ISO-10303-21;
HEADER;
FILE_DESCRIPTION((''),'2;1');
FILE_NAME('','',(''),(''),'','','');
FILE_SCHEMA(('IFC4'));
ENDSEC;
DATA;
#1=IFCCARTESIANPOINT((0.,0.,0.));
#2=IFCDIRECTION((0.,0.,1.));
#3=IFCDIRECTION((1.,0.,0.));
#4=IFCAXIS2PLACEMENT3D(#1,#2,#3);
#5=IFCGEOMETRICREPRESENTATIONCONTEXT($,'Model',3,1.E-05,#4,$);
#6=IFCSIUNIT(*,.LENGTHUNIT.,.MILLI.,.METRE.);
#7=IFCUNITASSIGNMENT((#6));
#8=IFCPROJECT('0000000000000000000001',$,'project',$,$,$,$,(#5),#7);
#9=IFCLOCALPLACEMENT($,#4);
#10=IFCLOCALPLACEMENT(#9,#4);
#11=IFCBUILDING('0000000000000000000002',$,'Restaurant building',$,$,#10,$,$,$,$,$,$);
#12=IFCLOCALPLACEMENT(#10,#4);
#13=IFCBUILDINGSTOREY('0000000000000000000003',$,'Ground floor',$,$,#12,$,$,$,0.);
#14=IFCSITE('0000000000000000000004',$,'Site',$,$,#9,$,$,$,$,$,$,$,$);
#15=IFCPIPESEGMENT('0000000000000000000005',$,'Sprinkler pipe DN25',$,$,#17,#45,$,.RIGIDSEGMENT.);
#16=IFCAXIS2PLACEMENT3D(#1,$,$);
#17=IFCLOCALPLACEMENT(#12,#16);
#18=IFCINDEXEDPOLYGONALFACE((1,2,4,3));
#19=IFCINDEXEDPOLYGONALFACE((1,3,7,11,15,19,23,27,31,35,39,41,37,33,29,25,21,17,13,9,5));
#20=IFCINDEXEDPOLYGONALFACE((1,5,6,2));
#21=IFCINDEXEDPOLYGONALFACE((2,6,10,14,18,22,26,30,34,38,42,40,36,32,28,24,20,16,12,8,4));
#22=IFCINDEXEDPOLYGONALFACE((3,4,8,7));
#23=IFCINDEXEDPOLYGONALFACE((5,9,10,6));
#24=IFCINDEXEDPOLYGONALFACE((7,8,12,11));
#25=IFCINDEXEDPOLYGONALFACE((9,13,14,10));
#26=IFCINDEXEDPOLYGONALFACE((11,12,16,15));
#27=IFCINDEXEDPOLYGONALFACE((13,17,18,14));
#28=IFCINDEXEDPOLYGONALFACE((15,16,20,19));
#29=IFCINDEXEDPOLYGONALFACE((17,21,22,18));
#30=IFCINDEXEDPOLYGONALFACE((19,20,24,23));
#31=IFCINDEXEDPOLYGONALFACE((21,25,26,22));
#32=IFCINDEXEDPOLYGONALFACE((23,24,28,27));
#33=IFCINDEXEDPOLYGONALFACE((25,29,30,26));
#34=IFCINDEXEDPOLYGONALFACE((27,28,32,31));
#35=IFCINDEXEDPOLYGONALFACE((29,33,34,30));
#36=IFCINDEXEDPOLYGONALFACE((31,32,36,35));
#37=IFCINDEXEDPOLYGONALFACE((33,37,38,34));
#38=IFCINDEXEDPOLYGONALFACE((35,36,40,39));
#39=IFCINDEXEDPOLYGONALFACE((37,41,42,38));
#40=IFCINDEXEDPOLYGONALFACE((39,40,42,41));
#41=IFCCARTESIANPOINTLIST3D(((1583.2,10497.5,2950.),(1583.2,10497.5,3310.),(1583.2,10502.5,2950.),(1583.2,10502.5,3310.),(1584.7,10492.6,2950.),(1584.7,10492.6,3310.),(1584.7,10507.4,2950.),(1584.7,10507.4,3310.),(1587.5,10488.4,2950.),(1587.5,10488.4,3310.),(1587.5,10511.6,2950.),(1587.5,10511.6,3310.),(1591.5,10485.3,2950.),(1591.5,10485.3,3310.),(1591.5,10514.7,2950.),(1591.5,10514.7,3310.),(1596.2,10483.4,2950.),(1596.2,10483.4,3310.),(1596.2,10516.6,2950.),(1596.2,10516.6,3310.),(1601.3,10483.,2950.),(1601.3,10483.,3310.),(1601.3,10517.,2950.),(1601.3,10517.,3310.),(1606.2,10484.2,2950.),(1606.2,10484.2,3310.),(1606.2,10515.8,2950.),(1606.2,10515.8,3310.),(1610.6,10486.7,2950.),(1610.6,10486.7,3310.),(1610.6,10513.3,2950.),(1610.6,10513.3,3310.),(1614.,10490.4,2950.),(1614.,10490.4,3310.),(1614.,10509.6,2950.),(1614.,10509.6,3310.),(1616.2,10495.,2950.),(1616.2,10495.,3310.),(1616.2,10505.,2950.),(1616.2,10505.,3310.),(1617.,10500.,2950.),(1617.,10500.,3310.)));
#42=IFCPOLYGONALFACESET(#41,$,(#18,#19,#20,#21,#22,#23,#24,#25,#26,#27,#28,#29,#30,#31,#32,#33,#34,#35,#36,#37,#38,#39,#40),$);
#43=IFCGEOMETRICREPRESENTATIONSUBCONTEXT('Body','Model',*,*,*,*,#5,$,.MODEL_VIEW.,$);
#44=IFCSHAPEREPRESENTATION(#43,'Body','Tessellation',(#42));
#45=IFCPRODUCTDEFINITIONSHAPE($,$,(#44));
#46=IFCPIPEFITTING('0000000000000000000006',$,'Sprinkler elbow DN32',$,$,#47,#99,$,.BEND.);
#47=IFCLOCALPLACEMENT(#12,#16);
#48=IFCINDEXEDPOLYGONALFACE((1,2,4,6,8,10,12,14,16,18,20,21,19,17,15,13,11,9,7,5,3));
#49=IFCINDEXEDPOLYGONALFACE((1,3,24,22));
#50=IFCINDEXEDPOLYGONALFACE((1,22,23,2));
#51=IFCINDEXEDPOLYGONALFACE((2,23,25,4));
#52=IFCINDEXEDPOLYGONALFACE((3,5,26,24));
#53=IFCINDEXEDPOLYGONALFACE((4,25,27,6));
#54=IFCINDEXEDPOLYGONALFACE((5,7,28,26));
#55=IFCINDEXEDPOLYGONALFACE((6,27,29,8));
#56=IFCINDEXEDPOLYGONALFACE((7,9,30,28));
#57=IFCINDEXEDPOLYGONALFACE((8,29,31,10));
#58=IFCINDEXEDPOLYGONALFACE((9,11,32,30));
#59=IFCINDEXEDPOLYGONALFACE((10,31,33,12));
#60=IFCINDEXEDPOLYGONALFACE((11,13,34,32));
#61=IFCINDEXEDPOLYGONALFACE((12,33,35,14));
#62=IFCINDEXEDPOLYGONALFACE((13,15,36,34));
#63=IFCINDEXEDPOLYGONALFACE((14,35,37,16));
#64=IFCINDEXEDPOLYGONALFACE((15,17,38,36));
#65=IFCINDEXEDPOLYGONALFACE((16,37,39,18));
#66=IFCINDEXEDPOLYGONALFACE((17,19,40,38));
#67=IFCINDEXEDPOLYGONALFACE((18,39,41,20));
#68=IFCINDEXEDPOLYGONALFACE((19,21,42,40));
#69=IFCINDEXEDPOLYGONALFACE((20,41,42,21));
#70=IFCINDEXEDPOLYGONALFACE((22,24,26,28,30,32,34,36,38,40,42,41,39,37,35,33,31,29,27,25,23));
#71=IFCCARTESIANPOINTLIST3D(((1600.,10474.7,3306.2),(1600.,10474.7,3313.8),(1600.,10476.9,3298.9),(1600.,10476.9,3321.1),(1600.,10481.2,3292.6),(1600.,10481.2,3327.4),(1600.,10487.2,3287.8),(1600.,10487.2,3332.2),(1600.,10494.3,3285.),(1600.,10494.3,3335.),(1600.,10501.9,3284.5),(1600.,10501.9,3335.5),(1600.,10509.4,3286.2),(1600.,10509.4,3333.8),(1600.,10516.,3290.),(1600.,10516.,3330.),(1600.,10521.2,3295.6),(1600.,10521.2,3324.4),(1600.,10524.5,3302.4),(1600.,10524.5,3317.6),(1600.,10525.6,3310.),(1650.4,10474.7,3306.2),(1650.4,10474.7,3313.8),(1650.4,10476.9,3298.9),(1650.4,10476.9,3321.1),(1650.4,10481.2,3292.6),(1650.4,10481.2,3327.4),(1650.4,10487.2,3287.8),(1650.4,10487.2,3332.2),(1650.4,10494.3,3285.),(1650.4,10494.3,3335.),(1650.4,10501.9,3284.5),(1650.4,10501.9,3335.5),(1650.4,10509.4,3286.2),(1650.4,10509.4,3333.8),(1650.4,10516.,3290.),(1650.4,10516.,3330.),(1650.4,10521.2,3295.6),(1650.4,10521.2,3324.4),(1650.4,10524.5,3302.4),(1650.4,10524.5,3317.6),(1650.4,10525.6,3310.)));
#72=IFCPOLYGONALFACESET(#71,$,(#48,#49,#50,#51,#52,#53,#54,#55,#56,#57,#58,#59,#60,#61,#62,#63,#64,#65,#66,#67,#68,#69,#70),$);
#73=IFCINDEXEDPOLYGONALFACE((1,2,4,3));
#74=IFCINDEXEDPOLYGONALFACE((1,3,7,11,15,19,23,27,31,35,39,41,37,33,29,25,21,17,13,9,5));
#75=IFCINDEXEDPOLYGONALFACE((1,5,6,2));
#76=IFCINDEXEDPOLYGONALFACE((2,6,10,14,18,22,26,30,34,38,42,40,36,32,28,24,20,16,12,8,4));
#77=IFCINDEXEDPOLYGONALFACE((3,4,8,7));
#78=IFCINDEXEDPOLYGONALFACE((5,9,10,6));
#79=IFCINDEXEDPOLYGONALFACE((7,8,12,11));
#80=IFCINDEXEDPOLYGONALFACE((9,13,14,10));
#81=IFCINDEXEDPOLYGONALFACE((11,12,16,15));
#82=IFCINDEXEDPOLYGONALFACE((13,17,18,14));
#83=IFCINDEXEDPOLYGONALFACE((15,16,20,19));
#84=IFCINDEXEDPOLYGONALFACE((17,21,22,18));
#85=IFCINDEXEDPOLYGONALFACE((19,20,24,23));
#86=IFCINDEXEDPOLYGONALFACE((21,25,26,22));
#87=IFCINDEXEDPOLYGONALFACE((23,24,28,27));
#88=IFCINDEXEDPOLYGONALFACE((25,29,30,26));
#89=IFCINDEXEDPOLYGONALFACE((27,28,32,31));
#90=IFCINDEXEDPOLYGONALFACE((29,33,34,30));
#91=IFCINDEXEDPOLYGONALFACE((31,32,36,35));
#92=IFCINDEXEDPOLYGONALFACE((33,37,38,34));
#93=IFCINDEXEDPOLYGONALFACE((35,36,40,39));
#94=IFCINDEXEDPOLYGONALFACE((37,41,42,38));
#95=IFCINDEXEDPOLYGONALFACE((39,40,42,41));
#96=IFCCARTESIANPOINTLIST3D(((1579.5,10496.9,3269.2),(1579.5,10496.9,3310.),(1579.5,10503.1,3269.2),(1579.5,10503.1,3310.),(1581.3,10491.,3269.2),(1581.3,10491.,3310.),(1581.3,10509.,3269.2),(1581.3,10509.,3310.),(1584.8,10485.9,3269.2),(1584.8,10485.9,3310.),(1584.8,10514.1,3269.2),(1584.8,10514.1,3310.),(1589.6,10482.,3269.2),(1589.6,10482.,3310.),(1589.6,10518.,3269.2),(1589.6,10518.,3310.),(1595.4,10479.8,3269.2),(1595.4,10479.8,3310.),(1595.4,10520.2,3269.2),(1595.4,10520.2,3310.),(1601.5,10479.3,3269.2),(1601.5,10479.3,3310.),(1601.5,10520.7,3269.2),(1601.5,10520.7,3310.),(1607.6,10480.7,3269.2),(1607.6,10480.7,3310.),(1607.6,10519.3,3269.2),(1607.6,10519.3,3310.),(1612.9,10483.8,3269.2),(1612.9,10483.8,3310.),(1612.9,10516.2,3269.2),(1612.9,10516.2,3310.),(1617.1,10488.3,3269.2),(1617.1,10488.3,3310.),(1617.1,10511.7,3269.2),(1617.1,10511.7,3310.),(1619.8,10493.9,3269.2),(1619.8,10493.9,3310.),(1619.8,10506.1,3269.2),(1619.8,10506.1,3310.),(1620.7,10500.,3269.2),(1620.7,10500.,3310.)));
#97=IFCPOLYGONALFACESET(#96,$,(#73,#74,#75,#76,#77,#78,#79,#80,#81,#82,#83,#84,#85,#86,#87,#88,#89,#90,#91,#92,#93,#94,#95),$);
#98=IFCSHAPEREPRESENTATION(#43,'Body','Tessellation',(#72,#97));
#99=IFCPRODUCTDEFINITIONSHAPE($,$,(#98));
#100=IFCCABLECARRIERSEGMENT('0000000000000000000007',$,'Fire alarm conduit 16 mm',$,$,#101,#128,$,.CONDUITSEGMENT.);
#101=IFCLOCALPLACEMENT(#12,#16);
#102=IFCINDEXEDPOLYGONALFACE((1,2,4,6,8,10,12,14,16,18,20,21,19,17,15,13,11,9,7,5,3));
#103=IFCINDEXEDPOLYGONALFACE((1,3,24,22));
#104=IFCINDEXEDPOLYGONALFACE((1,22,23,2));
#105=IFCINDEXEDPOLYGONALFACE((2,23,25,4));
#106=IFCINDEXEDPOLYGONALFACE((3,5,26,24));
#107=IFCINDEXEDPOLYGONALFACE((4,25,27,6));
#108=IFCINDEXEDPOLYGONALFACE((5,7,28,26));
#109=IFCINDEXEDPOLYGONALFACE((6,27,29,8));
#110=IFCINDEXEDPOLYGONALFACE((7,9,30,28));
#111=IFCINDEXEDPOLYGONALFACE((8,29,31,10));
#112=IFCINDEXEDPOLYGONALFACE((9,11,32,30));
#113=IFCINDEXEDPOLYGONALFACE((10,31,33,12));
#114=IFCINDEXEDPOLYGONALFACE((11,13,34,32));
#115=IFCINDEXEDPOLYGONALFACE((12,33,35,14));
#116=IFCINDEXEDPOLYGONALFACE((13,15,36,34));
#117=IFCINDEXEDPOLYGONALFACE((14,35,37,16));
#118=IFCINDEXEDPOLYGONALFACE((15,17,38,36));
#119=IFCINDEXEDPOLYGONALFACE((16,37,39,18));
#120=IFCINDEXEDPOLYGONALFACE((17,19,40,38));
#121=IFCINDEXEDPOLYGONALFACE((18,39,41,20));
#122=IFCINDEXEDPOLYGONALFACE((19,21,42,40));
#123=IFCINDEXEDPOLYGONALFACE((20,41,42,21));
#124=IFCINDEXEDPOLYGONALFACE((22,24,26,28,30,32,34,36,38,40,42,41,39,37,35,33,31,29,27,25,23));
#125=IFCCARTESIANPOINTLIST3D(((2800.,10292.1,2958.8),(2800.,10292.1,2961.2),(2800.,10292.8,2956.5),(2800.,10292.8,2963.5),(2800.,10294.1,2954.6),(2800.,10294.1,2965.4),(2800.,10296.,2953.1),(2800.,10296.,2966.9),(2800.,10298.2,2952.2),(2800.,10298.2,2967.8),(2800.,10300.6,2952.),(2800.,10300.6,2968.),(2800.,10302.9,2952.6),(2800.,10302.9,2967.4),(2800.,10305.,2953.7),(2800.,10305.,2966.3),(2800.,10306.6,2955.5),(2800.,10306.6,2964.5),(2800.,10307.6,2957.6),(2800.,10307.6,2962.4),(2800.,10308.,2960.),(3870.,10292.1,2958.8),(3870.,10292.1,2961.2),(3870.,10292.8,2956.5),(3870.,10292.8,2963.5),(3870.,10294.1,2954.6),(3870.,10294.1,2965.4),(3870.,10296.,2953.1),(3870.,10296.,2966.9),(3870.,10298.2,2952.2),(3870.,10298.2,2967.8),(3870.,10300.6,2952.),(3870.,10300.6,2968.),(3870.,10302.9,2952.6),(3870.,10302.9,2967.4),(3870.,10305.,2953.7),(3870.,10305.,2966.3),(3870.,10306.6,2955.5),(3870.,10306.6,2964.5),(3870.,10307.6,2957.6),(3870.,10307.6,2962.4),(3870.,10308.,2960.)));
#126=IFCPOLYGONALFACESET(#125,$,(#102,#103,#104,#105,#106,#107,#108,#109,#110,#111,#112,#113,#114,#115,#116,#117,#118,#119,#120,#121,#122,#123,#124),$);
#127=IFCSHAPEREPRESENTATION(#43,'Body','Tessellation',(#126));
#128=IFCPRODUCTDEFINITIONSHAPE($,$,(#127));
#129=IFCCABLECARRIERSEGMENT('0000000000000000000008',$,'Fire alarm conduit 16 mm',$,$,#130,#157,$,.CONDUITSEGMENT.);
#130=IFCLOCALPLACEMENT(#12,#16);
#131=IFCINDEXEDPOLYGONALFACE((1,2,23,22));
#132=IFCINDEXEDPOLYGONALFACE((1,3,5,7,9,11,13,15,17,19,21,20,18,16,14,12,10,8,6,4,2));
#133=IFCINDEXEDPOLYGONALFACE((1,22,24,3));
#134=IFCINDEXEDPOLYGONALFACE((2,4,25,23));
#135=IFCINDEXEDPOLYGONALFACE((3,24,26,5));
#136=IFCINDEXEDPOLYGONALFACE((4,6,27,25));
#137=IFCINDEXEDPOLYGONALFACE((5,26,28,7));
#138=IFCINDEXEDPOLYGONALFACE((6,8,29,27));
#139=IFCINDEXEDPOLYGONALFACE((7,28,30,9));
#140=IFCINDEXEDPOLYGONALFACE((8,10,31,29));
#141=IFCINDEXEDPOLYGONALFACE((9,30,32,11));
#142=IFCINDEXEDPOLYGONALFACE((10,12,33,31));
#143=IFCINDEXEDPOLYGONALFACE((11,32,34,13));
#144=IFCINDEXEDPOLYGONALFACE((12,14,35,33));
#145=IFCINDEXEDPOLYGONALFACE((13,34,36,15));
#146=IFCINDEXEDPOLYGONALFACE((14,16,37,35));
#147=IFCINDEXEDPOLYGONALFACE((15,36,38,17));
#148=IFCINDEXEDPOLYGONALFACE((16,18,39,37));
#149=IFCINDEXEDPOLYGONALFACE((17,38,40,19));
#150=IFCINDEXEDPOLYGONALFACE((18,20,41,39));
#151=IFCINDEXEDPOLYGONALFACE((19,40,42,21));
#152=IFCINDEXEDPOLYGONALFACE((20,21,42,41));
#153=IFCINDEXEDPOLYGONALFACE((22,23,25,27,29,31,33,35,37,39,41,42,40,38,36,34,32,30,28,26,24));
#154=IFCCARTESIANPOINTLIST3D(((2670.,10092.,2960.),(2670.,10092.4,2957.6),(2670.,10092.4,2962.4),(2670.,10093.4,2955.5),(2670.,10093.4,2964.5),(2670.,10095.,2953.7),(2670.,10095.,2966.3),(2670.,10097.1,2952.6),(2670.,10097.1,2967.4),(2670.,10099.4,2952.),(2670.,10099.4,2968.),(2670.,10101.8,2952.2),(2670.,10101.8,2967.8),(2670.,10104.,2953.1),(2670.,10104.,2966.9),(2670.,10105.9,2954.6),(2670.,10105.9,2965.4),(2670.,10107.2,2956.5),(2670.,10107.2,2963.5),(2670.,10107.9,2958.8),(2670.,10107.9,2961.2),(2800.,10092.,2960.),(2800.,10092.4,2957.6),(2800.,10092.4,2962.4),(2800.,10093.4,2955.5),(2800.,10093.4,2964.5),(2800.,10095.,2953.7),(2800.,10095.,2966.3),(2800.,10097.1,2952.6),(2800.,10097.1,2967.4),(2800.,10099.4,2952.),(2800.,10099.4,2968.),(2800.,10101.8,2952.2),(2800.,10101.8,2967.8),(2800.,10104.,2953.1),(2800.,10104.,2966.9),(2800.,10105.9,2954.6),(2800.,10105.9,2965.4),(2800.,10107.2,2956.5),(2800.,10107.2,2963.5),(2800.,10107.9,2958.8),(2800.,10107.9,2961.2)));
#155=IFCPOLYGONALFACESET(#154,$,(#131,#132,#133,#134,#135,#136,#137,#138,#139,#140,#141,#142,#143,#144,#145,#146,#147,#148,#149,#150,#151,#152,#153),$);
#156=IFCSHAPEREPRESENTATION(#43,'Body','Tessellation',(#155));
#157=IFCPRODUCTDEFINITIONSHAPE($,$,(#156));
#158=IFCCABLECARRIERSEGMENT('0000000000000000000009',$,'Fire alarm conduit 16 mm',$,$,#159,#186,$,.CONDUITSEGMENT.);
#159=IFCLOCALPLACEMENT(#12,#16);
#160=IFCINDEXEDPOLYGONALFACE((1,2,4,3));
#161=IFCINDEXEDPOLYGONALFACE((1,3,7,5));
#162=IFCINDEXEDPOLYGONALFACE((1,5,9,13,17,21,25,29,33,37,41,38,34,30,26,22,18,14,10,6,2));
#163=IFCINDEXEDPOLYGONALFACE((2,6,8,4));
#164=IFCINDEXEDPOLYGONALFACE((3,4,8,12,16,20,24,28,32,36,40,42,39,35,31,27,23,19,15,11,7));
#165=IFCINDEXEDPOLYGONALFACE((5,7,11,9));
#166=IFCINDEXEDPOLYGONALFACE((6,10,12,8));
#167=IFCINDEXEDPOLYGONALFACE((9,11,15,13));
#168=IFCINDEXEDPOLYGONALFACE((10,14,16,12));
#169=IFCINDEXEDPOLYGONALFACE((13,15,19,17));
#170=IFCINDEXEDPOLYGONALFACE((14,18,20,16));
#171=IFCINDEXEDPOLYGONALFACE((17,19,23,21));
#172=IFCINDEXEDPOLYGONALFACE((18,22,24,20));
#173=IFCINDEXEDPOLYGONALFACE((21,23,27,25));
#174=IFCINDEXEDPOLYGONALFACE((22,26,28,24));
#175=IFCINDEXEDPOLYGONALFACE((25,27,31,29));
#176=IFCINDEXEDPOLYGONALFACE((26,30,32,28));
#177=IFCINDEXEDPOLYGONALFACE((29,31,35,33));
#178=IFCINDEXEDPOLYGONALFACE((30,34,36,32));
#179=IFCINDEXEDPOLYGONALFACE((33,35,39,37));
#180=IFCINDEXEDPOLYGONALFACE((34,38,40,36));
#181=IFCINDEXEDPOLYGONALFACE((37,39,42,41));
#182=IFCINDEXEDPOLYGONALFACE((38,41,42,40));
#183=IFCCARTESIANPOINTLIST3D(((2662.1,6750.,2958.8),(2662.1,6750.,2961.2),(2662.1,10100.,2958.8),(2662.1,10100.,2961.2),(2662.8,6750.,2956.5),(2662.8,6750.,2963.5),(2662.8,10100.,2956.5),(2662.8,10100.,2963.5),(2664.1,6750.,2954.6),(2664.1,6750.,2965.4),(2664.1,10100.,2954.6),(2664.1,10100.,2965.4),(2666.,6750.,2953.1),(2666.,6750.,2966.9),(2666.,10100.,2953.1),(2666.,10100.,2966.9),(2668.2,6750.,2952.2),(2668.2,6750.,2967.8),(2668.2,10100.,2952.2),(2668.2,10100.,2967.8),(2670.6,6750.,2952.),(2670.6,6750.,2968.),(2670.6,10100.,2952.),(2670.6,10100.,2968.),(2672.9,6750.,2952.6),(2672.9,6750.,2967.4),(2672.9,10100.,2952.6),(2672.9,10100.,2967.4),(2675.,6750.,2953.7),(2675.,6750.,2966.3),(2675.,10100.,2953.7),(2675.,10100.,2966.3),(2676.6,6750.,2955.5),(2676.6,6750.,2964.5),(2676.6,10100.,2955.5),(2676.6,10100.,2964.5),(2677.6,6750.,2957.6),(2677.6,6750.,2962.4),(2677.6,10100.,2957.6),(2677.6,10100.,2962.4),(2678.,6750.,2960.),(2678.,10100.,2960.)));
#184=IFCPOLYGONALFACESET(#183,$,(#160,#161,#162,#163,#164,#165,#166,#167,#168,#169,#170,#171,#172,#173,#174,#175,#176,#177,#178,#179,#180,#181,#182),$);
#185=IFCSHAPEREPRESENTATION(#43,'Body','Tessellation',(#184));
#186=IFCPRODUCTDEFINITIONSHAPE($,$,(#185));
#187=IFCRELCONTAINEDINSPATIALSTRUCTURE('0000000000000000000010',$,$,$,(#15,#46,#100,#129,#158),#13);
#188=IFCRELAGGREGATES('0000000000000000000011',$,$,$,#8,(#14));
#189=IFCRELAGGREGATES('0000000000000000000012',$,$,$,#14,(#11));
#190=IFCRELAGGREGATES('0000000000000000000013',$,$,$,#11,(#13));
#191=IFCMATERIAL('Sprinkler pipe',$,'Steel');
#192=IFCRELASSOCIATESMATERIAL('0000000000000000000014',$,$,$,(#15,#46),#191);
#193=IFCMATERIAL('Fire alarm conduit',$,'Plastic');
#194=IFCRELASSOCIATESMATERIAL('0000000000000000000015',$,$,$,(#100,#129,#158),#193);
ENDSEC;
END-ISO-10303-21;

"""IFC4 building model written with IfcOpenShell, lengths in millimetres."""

from ifc_helpers import new_model, si_unit, frame, origin_with_axes, origin_2d, place, context, subcontext, project, spatial, circle, extrude, material, element, save


model = new_model("IFC4")

# Units and contexts
model_context = context("Model", 3, precision=1e-05, world=origin_with_axes())
body_context = subcontext(model_context, "Body", "Model", "MODEL_VIEW")
ifc_project = project(units=[si_unit("LENGTHUNIT", "METRE", prefix="MILLI")], contexts=[model_context])

# Site, building, storey
site_placement = place(None, origin_with_axes())
site = spatial("IfcSite", under=ifc_project, at=site_placement, Name="Site")
building_placement = place(site_placement, origin_with_axes())
building = spatial("IfcBuilding", under=site, at=building_placement, Name="Restaurant building")
storey_placement = place(building_placement, origin_with_axes())
storey = spatial("IfcBuildingStorey", under=building, at=storey_placement, Name="Ground floor", Elevation=0.0)

# Pipe segment
ifc_material_1 = material(Name="Sprinkler pipe", Category="Steel")
pipe_segment_1_placement = place(storey_placement, frame((1600.0, 10500.0, 3310.0)))
element("IfcPipeSegment", 1, at=pipe_segment_1_placement, inside=storey, material=ifc_material_1, Name="Sprinkler pipe DN25", PredefinedType="RIGIDSEGMENT", context=body_context, shape_type="SweptSolid", body=[
    extrude(circle(Radius=17.0, at=origin_2d()), frame((0.0, 0.0, 0.0), z_axis=(0.0, 0.0, -1.0), x_axis=(1.0, 0.0, 0.0)), (0.0, 0.0, 1.0), 360.0),
])

# Pipe fitting
pipe_fitting_1_placement = place(storey_placement, frame((1600.0, 10500.0, 3310.0)))
element("IfcPipeFitting", 2, at=pipe_fitting_1_placement, inside=storey, material=ifc_material_1, Name="Sprinkler elbow DN32", PredefinedType="BEND", context=body_context, shape_type="SweptSolid", body=[
    extrude(circle(Radius=25.6, at=origin_2d()), frame((0.0, 0.0, 0.0), z_axis=(1.0, 0.0, 0.0), x_axis=(0.0, 1.0, 0.0)), (0.0, 0.0, 1.0), 50.4),
    extrude(circle(Radius=20.7, at=origin_2d()), frame((0.0, 0.0, 0.0), z_axis=(0.0, 0.0, -1.0), x_axis=(1.0, 0.0, 0.0)), (0.0, 0.0, 1.0), 40.8),
])

# Cable carrier segments
ifc_material_2 = material(Name="Fire alarm conduit", Category="Plastic")
cable_carrier_segment_1_placement = place(storey_placement, frame((2800.0, 10300.0, 2960.0)))
element("IfcCableCarrierSegment", 3, at=cable_carrier_segment_1_placement, inside=storey, material=ifc_material_2, Name="Fire alarm conduit 16 mm", PredefinedType="CONDUITSEGMENT", context=body_context, shape_type="SweptSolid", body=[
    extrude(circle(Radius=8.0, at=origin_2d()), frame((0.0, 0.0, 0.0), z_axis=(1.0, 0.0, 0.0), x_axis=(0.0, 1.0, 0.0)), (0.0, 0.0, 1.0), 1070.0),
])
cable_carrier_segment_2_placement = place(storey_placement, frame((2800.0, 10100.0, 2960.0)))
element("IfcCableCarrierSegment", 4, at=cable_carrier_segment_2_placement, inside=storey, material=ifc_material_2, Name="Fire alarm conduit 16 mm", PredefinedType="CONDUITSEGMENT", context=body_context, shape_type="SweptSolid", body=[
    extrude(circle(Radius=8.0, at=origin_2d()), frame((0.0, 0.0, 0.0), z_axis=(-1.0, 0.0, 0.0), x_axis=(0.0, -1.0, 0.0)), (0.0, 0.0, 1.0), 130.0),
])
cable_carrier_segment_3_placement = place(storey_placement, frame((2670.0, 10100.0, 2960.0)))
element("IfcCableCarrierSegment", 5, at=cable_carrier_segment_3_placement, inside=storey, material=ifc_material_2, Name="Fire alarm conduit 16 mm", PredefinedType="CONDUITSEGMENT", context=body_context, shape_type="SweptSolid", body=[
    extrude(circle(Radius=8.0, at=origin_2d()), frame((0.0, 0.0, 0.0), z_axis=(0.0, -1.0, 0.0), x_axis=(1.0, 0.0, 0.0)), (0.0, 0.0, 1.0), 3350.0),
])

save(model, "model.ifc")
